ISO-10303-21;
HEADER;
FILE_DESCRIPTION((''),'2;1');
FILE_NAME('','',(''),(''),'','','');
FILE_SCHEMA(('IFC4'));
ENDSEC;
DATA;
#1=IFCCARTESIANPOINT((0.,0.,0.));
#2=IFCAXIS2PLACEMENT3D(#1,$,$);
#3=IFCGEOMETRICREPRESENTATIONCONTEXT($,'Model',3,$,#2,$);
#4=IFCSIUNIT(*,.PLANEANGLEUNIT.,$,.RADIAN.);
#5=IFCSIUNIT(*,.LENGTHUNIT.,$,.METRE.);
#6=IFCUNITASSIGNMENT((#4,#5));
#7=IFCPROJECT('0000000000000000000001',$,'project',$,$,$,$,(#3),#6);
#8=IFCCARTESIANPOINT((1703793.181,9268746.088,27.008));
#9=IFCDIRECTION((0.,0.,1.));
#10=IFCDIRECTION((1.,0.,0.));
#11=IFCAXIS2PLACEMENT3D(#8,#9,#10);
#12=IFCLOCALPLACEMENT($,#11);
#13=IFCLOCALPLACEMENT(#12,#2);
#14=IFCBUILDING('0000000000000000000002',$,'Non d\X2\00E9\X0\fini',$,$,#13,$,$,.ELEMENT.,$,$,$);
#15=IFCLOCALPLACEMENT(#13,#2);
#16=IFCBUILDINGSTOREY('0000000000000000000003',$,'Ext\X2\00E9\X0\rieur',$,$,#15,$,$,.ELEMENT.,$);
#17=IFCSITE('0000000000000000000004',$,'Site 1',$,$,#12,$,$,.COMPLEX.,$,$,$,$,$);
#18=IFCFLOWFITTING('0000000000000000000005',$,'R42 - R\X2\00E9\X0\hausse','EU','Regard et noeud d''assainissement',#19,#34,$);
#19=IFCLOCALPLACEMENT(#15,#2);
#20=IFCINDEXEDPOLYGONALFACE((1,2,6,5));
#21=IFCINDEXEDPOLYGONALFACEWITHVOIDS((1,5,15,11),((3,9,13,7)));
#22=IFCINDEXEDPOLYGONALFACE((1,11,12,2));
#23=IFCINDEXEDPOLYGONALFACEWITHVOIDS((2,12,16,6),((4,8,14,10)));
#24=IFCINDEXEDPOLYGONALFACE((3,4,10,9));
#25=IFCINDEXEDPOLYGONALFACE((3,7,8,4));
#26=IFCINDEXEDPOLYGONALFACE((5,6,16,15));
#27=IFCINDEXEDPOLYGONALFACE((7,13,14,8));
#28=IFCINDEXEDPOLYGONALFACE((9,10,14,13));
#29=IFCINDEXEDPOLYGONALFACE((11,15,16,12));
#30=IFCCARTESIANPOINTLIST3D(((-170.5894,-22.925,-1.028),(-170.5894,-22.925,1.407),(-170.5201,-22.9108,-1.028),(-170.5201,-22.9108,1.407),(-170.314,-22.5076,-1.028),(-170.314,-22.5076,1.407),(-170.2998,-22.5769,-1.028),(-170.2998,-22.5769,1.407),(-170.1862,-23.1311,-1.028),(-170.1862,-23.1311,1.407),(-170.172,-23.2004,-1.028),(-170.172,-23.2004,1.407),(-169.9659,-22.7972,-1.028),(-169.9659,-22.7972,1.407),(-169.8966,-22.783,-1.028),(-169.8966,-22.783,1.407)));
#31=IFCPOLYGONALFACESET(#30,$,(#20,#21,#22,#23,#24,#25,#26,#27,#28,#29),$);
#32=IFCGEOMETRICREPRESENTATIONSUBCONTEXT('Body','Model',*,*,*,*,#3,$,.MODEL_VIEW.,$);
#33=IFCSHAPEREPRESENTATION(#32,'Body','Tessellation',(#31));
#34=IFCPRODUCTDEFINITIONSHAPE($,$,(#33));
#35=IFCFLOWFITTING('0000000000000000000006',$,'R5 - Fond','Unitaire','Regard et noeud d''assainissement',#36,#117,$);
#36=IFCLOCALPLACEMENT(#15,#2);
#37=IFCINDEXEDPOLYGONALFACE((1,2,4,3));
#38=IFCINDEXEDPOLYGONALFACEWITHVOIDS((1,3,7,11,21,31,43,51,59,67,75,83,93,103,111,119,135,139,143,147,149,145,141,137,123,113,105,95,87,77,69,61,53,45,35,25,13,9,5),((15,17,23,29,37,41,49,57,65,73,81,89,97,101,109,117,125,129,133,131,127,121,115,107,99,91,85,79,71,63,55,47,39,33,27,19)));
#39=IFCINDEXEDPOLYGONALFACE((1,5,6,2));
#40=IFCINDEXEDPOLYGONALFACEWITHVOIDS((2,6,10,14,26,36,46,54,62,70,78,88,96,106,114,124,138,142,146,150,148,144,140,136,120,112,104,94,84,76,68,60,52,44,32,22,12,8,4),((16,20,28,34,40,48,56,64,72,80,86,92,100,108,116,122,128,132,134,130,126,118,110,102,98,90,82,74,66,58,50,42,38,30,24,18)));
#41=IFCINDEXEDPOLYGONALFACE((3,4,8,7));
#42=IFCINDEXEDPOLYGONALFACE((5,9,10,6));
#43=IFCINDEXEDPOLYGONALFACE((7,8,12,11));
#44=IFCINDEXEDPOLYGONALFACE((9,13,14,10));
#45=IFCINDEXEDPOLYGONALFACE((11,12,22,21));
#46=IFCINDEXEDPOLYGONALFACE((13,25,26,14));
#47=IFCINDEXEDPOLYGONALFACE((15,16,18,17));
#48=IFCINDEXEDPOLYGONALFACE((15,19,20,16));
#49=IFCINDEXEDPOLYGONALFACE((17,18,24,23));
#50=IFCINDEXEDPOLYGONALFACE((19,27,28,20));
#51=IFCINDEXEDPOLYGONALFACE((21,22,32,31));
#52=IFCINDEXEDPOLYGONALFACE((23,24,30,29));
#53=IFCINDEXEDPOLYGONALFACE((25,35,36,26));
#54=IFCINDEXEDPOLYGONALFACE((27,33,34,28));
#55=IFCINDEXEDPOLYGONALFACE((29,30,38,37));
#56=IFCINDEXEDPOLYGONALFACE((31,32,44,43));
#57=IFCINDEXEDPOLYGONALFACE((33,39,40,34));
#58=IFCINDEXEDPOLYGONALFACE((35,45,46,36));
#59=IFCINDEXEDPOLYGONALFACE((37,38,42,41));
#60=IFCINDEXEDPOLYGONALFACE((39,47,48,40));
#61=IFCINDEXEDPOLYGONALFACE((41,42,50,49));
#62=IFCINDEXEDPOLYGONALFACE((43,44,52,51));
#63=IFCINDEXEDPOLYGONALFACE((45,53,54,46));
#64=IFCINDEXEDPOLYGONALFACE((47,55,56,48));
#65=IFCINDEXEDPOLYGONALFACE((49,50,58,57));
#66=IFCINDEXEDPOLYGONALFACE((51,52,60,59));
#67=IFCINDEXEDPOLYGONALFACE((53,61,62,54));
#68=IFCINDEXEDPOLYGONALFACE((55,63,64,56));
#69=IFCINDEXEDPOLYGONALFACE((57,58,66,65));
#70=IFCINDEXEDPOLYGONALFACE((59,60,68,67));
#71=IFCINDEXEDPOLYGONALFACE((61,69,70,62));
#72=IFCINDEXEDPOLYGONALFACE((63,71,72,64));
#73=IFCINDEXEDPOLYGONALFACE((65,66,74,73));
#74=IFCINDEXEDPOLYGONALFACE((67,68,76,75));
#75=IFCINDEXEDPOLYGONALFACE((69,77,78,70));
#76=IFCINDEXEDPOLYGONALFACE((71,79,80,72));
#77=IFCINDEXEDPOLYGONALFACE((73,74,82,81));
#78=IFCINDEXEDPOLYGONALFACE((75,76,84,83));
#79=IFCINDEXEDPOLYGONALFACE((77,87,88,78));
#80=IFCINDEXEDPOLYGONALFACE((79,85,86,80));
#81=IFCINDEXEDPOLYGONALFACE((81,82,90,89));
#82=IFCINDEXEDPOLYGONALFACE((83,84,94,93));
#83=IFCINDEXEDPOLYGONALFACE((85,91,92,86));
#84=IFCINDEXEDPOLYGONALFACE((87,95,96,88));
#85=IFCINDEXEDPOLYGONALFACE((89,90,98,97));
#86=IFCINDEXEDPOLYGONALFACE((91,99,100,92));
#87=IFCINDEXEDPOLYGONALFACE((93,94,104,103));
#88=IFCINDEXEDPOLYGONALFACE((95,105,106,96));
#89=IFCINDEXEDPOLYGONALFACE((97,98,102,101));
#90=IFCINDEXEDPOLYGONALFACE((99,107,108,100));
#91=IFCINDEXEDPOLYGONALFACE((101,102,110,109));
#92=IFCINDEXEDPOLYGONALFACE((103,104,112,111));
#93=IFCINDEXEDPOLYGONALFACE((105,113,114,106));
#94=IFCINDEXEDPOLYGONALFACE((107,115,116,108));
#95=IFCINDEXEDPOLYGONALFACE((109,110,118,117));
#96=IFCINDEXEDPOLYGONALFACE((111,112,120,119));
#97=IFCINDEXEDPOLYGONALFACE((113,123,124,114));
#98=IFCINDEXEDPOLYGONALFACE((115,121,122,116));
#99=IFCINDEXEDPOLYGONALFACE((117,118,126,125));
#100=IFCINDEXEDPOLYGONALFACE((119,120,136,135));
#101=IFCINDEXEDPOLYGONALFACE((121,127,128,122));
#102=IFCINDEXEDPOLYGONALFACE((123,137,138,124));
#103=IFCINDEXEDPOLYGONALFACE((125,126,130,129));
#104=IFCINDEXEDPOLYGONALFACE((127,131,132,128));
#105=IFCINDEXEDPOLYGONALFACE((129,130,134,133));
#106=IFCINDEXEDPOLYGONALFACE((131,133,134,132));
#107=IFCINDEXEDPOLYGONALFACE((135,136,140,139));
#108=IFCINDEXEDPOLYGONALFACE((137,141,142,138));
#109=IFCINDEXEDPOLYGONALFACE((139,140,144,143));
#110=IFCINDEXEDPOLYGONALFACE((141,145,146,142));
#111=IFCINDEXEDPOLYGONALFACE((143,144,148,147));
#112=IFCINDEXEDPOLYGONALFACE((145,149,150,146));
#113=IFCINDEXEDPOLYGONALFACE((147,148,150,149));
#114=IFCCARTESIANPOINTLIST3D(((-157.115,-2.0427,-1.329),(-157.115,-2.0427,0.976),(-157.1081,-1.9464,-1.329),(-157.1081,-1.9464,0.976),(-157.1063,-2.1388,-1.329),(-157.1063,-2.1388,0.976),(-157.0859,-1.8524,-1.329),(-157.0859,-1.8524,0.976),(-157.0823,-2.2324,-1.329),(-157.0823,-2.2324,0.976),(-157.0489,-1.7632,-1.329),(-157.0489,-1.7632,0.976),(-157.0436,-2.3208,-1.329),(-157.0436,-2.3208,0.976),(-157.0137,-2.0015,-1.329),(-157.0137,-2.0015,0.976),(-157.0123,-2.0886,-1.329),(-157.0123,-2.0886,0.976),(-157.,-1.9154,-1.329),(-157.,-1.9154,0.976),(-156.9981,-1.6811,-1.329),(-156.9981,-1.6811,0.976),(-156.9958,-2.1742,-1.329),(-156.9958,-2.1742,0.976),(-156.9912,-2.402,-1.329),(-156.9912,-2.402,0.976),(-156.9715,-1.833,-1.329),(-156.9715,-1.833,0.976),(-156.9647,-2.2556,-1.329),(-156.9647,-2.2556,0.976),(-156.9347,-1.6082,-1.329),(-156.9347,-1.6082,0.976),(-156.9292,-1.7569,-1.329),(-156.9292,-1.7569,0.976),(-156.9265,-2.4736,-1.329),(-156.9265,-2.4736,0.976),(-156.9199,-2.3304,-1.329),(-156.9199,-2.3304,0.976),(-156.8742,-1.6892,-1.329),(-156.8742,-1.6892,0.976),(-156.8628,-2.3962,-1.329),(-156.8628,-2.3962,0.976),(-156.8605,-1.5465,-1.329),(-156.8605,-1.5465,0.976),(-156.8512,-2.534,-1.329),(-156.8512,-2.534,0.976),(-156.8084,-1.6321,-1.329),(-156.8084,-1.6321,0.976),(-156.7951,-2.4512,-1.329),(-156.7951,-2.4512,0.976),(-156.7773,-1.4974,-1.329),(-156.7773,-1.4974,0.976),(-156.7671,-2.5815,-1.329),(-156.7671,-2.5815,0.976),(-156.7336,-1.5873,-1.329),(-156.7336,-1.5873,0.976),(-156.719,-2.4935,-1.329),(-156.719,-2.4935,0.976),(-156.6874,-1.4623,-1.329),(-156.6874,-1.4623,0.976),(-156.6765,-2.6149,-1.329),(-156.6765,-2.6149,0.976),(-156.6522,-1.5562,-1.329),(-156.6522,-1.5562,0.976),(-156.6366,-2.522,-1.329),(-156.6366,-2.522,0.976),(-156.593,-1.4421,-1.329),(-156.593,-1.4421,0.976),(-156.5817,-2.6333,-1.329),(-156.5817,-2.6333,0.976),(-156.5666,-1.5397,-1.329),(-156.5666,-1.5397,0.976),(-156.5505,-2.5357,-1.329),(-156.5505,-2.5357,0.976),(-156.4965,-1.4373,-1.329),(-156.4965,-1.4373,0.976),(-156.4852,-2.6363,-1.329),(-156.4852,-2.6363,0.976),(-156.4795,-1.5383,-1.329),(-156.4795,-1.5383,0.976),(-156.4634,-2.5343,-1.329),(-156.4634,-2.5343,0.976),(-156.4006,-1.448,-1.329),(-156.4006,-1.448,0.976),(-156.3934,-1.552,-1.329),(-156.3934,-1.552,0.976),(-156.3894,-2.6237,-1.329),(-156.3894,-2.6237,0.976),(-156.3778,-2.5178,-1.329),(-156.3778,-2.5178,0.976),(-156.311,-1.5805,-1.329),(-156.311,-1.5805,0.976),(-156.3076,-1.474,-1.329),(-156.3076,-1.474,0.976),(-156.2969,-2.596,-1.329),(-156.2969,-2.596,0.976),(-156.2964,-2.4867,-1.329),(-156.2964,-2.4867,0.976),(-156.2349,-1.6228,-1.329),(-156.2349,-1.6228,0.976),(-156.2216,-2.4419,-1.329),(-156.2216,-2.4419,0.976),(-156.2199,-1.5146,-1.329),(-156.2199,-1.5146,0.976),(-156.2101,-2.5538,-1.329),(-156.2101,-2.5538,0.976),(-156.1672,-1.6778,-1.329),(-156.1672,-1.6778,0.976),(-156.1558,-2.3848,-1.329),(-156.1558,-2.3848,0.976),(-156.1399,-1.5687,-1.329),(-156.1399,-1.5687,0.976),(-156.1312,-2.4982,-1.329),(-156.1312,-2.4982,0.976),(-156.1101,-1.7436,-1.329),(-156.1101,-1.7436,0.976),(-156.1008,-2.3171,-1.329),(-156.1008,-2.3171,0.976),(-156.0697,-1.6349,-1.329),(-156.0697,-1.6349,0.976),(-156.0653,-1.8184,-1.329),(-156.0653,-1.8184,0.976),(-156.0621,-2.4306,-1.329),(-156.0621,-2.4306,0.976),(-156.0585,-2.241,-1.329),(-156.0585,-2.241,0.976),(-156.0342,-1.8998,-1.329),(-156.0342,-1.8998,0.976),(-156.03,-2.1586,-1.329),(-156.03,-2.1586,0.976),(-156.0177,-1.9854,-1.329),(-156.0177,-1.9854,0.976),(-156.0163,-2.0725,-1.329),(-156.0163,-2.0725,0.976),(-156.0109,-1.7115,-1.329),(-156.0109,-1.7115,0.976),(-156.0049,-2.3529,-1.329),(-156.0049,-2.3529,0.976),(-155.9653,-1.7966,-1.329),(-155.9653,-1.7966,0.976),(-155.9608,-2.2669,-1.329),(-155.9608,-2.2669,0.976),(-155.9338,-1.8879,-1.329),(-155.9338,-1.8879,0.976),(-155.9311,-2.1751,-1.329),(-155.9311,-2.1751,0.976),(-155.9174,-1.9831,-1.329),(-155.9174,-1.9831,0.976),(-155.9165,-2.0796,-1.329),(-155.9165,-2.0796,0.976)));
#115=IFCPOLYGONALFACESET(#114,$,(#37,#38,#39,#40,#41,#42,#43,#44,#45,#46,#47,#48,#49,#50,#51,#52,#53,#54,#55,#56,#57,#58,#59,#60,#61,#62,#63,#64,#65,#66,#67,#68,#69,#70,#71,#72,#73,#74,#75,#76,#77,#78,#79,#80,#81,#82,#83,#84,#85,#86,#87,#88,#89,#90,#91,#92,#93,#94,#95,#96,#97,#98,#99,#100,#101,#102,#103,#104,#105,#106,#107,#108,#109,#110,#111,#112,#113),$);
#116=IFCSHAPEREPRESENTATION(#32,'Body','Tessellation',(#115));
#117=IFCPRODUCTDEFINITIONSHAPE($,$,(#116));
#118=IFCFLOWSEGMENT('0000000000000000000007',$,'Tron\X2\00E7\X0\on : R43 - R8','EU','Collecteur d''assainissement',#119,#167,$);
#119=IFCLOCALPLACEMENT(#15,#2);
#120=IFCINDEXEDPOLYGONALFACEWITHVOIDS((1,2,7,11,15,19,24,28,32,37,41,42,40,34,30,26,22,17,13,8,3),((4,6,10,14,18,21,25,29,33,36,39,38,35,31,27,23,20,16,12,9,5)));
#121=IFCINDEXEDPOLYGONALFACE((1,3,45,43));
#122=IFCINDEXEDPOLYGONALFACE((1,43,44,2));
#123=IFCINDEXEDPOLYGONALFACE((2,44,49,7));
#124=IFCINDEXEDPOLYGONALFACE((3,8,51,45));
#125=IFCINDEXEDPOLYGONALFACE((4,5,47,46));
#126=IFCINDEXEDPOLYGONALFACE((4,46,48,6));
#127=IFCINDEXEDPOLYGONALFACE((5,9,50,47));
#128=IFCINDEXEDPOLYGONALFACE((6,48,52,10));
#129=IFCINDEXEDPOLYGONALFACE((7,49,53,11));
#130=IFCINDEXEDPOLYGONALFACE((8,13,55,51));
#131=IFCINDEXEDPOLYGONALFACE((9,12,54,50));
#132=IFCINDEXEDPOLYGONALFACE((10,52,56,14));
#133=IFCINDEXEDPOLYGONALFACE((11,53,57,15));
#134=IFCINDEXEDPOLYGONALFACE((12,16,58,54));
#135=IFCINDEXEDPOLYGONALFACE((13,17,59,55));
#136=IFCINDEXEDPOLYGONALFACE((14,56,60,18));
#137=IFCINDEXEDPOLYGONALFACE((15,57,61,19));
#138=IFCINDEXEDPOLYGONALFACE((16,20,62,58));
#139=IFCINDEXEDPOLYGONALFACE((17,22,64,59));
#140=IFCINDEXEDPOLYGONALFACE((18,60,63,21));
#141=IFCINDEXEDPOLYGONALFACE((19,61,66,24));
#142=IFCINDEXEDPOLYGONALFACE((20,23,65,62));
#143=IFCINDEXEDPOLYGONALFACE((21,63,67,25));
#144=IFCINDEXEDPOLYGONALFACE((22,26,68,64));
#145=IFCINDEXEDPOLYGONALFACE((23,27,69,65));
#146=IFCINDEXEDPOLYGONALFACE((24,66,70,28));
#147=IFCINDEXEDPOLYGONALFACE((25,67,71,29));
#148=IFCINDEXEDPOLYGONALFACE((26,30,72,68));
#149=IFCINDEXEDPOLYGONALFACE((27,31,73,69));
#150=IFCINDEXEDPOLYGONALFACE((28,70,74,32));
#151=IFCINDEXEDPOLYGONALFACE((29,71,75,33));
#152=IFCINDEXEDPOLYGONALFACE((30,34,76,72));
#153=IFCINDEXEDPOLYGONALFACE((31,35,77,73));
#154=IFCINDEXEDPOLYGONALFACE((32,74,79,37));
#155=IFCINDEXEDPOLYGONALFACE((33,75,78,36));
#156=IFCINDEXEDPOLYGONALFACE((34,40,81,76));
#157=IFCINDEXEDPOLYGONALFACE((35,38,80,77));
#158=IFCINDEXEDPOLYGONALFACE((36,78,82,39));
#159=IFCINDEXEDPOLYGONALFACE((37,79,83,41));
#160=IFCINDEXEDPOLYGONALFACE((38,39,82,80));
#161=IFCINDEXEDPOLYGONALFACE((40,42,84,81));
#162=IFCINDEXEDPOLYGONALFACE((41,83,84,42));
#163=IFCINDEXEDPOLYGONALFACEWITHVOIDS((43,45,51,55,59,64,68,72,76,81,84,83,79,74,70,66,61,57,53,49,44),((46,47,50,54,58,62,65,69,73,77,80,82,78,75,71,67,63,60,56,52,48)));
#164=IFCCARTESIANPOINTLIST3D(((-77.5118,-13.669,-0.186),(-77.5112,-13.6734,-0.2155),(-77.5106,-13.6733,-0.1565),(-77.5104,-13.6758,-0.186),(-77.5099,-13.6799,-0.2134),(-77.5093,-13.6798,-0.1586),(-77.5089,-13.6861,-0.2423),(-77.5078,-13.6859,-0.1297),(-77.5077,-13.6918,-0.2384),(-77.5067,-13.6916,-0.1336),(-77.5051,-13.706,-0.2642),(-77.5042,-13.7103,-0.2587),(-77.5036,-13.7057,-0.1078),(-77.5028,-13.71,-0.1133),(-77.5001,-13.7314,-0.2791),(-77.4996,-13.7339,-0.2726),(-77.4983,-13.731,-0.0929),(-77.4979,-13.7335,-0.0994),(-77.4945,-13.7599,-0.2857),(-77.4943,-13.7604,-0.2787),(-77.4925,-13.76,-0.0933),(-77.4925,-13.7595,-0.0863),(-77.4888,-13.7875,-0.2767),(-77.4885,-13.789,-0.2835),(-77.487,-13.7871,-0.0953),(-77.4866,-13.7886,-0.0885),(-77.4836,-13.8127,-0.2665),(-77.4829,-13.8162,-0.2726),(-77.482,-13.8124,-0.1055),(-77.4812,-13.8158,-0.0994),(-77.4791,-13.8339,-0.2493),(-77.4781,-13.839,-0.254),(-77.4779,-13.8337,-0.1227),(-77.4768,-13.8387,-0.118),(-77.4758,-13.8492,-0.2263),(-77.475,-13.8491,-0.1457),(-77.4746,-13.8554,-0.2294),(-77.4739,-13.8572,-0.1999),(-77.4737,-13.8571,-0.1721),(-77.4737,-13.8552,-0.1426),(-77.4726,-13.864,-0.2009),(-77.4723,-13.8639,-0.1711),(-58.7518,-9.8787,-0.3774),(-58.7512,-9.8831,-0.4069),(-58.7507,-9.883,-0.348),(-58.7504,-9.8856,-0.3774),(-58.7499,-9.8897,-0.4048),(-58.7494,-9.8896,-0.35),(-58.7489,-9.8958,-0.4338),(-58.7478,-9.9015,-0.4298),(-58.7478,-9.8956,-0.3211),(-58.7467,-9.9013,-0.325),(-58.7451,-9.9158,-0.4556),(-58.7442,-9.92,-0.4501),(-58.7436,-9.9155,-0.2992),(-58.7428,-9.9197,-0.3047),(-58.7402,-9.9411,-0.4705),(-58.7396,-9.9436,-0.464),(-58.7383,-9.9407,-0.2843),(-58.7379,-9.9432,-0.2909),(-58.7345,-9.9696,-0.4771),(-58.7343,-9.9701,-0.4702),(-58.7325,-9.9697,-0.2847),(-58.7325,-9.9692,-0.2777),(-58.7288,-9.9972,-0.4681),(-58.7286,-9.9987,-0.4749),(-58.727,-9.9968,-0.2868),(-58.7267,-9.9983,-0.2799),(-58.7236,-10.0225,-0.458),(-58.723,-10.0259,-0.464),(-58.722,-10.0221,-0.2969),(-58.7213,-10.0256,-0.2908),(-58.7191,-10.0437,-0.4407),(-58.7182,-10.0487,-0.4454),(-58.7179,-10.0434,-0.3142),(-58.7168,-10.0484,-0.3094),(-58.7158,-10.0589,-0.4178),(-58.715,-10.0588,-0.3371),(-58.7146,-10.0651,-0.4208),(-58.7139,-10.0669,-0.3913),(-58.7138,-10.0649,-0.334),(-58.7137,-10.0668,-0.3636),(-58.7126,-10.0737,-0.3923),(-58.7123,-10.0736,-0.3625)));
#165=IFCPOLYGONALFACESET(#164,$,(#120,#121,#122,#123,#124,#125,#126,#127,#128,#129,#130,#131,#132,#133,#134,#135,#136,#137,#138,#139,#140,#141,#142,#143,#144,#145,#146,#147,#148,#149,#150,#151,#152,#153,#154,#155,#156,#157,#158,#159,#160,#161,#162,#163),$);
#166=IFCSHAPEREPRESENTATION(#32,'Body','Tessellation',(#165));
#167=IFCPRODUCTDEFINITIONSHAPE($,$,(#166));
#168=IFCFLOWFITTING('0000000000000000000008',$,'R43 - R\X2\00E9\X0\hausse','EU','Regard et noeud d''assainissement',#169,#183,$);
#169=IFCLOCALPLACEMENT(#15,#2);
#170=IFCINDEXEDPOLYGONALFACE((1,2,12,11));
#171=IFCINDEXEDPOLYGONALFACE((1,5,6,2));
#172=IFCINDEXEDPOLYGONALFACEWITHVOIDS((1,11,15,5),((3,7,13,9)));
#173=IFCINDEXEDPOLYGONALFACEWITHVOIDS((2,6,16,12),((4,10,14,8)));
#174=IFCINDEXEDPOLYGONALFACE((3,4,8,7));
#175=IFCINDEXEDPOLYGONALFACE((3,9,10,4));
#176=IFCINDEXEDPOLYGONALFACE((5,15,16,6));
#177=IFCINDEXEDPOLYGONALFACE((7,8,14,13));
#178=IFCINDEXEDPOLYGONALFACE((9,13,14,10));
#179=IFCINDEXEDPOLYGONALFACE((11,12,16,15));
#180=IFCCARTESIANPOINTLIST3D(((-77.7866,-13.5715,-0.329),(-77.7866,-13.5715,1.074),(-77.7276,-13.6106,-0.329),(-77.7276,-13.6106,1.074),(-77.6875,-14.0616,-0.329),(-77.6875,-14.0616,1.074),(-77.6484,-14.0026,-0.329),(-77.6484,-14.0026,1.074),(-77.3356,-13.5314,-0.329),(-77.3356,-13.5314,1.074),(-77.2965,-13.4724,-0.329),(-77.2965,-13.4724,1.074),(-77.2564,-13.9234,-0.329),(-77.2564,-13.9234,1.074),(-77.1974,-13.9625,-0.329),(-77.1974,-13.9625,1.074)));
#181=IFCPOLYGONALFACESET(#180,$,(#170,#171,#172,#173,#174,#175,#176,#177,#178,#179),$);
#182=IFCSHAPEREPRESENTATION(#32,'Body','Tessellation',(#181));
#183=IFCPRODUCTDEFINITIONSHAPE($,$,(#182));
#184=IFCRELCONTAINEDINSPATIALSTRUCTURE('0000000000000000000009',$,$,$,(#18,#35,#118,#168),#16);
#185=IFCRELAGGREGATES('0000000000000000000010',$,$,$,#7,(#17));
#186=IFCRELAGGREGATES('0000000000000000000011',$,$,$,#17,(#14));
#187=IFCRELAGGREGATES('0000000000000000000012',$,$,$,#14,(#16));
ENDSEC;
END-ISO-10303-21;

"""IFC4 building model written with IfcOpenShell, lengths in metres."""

from ifc_helpers import new_model, si_unit, frame, origin, origin_2d, place, context, subcontext, project, spatial, hollow_rectangle, hollow_circle, extrude, element, save


model = new_model("IFC4")

# Units and contexts
model_context = context("Model", 3, world=origin())
body_context = subcontext(model_context, "Body", "Model", "MODEL_VIEW")
ifc_project = project(units=[si_unit("PLANEANGLEUNIT", "RADIAN"), si_unit("LENGTHUNIT", "METRE")], contexts=[model_context])

# Site, building, storey
site_placement = place(None, frame((1703793.181, 9268746.088, 27.008), z_axis=(0.0, 0.0, 1.0), x_axis=(1.0, 0.0, 0.0)))
site = spatial("IfcSite", under=ifc_project, at=site_placement, Name="Site 1", CompositionType="COMPLEX")
building_placement = place(site_placement, origin())
building = spatial("IfcBuilding", under=site, at=building_placement, Name="Non défini", CompositionType="ELEMENT")
storey_placement = place(building_placement, origin())
storey = spatial("IfcBuildingStorey", under=building, at=storey_placement, Name="Extérieur", CompositionType="ELEMENT")

# Flow fittings
for number, where, name in (
    (1, (0.0, 0.0, 0.0), "R42 - Réhausse"),
):
    element("IfcFlowFitting", number, at=place(storey_placement, frame(where)), inside=storey, Name=name, Description="EU", ObjectType="Regard et noeud d'assainissement", context=body_context, shape_type="SweptSolid", body=[
        extrude(hollow_rectangle(XDim=0.5, YDim=0.5, WallThickness=0.05, at=origin_2d()), frame((-170.243, -22.854, -1.028), z_axis=(0.0, 0.0, 1.0), x_axis=(0.551, 0.835, 0.0)), (0.0, 0.0, 1.0), 2.435),
    ])
flow_fitting_1_placement = place(storey_placement, origin())
element("IfcFlowFitting", 2, at=flow_fitting_1_placement, inside=storey, Name="R5 - Fond", Description="Unitaire", ObjectType="Regard et noeud d'assainissement", context=body_context, shape_type="SweptSolid", body=[
    extrude(hollow_circle(Radius=0.6, WallThickness=0.1, at=origin_2d()), frame((-156.515, -2.037, -1.329), z_axis=(0.0, 0.0, 1.0), x_axis=(0.997, -0.071, 0.0)), (0.0, 0.0, 1.0), 2.305),
])

# Flow segment
flow_segment_1_placement = place(storey_placement, origin())
element("IfcFlowSegment", 3, at=flow_segment_1_placement, inside=storey, Name="Tronçon : R43 - R8", Description="EU", ObjectType="Collecteur d'assainissement", context=body_context, shape_type="SweptSolid", body=[
    extrude(hollow_circle(Radius=0.1, WallThickness=0.007, at=origin_2d()), frame((-77.492, -13.767, -0.186), z_axis=(0.98, 0.198, -0.01), x_axis=(-0.198, 0.98, 0.0)), (0.0, 0.0, 1.0), 19.14),
])

# Flow fitting
for number, where, name in (
    (4, (0.0, 0.0, 0.0), "R43 - Réhausse"),
):
    element("IfcFlowFitting", number, at=place(storey_placement, frame(where)), inside=storey, Name=name, Description="EU", ObjectType="Regard et noeud d'assainissement", context=body_context, shape_type="SweptSolid", body=[
        extrude(hollow_rectangle(XDim=0.5, YDim=0.5, WallThickness=0.05, at=origin_2d()), frame((-77.492, -13.767, -0.329), z_axis=(0.0, 0.0, 1.0), x_axis=(0.98, 0.198, 0.0)), (0.0, 0.0, 1.0), 1.403),
    ])

save(model, "model.ifc")
